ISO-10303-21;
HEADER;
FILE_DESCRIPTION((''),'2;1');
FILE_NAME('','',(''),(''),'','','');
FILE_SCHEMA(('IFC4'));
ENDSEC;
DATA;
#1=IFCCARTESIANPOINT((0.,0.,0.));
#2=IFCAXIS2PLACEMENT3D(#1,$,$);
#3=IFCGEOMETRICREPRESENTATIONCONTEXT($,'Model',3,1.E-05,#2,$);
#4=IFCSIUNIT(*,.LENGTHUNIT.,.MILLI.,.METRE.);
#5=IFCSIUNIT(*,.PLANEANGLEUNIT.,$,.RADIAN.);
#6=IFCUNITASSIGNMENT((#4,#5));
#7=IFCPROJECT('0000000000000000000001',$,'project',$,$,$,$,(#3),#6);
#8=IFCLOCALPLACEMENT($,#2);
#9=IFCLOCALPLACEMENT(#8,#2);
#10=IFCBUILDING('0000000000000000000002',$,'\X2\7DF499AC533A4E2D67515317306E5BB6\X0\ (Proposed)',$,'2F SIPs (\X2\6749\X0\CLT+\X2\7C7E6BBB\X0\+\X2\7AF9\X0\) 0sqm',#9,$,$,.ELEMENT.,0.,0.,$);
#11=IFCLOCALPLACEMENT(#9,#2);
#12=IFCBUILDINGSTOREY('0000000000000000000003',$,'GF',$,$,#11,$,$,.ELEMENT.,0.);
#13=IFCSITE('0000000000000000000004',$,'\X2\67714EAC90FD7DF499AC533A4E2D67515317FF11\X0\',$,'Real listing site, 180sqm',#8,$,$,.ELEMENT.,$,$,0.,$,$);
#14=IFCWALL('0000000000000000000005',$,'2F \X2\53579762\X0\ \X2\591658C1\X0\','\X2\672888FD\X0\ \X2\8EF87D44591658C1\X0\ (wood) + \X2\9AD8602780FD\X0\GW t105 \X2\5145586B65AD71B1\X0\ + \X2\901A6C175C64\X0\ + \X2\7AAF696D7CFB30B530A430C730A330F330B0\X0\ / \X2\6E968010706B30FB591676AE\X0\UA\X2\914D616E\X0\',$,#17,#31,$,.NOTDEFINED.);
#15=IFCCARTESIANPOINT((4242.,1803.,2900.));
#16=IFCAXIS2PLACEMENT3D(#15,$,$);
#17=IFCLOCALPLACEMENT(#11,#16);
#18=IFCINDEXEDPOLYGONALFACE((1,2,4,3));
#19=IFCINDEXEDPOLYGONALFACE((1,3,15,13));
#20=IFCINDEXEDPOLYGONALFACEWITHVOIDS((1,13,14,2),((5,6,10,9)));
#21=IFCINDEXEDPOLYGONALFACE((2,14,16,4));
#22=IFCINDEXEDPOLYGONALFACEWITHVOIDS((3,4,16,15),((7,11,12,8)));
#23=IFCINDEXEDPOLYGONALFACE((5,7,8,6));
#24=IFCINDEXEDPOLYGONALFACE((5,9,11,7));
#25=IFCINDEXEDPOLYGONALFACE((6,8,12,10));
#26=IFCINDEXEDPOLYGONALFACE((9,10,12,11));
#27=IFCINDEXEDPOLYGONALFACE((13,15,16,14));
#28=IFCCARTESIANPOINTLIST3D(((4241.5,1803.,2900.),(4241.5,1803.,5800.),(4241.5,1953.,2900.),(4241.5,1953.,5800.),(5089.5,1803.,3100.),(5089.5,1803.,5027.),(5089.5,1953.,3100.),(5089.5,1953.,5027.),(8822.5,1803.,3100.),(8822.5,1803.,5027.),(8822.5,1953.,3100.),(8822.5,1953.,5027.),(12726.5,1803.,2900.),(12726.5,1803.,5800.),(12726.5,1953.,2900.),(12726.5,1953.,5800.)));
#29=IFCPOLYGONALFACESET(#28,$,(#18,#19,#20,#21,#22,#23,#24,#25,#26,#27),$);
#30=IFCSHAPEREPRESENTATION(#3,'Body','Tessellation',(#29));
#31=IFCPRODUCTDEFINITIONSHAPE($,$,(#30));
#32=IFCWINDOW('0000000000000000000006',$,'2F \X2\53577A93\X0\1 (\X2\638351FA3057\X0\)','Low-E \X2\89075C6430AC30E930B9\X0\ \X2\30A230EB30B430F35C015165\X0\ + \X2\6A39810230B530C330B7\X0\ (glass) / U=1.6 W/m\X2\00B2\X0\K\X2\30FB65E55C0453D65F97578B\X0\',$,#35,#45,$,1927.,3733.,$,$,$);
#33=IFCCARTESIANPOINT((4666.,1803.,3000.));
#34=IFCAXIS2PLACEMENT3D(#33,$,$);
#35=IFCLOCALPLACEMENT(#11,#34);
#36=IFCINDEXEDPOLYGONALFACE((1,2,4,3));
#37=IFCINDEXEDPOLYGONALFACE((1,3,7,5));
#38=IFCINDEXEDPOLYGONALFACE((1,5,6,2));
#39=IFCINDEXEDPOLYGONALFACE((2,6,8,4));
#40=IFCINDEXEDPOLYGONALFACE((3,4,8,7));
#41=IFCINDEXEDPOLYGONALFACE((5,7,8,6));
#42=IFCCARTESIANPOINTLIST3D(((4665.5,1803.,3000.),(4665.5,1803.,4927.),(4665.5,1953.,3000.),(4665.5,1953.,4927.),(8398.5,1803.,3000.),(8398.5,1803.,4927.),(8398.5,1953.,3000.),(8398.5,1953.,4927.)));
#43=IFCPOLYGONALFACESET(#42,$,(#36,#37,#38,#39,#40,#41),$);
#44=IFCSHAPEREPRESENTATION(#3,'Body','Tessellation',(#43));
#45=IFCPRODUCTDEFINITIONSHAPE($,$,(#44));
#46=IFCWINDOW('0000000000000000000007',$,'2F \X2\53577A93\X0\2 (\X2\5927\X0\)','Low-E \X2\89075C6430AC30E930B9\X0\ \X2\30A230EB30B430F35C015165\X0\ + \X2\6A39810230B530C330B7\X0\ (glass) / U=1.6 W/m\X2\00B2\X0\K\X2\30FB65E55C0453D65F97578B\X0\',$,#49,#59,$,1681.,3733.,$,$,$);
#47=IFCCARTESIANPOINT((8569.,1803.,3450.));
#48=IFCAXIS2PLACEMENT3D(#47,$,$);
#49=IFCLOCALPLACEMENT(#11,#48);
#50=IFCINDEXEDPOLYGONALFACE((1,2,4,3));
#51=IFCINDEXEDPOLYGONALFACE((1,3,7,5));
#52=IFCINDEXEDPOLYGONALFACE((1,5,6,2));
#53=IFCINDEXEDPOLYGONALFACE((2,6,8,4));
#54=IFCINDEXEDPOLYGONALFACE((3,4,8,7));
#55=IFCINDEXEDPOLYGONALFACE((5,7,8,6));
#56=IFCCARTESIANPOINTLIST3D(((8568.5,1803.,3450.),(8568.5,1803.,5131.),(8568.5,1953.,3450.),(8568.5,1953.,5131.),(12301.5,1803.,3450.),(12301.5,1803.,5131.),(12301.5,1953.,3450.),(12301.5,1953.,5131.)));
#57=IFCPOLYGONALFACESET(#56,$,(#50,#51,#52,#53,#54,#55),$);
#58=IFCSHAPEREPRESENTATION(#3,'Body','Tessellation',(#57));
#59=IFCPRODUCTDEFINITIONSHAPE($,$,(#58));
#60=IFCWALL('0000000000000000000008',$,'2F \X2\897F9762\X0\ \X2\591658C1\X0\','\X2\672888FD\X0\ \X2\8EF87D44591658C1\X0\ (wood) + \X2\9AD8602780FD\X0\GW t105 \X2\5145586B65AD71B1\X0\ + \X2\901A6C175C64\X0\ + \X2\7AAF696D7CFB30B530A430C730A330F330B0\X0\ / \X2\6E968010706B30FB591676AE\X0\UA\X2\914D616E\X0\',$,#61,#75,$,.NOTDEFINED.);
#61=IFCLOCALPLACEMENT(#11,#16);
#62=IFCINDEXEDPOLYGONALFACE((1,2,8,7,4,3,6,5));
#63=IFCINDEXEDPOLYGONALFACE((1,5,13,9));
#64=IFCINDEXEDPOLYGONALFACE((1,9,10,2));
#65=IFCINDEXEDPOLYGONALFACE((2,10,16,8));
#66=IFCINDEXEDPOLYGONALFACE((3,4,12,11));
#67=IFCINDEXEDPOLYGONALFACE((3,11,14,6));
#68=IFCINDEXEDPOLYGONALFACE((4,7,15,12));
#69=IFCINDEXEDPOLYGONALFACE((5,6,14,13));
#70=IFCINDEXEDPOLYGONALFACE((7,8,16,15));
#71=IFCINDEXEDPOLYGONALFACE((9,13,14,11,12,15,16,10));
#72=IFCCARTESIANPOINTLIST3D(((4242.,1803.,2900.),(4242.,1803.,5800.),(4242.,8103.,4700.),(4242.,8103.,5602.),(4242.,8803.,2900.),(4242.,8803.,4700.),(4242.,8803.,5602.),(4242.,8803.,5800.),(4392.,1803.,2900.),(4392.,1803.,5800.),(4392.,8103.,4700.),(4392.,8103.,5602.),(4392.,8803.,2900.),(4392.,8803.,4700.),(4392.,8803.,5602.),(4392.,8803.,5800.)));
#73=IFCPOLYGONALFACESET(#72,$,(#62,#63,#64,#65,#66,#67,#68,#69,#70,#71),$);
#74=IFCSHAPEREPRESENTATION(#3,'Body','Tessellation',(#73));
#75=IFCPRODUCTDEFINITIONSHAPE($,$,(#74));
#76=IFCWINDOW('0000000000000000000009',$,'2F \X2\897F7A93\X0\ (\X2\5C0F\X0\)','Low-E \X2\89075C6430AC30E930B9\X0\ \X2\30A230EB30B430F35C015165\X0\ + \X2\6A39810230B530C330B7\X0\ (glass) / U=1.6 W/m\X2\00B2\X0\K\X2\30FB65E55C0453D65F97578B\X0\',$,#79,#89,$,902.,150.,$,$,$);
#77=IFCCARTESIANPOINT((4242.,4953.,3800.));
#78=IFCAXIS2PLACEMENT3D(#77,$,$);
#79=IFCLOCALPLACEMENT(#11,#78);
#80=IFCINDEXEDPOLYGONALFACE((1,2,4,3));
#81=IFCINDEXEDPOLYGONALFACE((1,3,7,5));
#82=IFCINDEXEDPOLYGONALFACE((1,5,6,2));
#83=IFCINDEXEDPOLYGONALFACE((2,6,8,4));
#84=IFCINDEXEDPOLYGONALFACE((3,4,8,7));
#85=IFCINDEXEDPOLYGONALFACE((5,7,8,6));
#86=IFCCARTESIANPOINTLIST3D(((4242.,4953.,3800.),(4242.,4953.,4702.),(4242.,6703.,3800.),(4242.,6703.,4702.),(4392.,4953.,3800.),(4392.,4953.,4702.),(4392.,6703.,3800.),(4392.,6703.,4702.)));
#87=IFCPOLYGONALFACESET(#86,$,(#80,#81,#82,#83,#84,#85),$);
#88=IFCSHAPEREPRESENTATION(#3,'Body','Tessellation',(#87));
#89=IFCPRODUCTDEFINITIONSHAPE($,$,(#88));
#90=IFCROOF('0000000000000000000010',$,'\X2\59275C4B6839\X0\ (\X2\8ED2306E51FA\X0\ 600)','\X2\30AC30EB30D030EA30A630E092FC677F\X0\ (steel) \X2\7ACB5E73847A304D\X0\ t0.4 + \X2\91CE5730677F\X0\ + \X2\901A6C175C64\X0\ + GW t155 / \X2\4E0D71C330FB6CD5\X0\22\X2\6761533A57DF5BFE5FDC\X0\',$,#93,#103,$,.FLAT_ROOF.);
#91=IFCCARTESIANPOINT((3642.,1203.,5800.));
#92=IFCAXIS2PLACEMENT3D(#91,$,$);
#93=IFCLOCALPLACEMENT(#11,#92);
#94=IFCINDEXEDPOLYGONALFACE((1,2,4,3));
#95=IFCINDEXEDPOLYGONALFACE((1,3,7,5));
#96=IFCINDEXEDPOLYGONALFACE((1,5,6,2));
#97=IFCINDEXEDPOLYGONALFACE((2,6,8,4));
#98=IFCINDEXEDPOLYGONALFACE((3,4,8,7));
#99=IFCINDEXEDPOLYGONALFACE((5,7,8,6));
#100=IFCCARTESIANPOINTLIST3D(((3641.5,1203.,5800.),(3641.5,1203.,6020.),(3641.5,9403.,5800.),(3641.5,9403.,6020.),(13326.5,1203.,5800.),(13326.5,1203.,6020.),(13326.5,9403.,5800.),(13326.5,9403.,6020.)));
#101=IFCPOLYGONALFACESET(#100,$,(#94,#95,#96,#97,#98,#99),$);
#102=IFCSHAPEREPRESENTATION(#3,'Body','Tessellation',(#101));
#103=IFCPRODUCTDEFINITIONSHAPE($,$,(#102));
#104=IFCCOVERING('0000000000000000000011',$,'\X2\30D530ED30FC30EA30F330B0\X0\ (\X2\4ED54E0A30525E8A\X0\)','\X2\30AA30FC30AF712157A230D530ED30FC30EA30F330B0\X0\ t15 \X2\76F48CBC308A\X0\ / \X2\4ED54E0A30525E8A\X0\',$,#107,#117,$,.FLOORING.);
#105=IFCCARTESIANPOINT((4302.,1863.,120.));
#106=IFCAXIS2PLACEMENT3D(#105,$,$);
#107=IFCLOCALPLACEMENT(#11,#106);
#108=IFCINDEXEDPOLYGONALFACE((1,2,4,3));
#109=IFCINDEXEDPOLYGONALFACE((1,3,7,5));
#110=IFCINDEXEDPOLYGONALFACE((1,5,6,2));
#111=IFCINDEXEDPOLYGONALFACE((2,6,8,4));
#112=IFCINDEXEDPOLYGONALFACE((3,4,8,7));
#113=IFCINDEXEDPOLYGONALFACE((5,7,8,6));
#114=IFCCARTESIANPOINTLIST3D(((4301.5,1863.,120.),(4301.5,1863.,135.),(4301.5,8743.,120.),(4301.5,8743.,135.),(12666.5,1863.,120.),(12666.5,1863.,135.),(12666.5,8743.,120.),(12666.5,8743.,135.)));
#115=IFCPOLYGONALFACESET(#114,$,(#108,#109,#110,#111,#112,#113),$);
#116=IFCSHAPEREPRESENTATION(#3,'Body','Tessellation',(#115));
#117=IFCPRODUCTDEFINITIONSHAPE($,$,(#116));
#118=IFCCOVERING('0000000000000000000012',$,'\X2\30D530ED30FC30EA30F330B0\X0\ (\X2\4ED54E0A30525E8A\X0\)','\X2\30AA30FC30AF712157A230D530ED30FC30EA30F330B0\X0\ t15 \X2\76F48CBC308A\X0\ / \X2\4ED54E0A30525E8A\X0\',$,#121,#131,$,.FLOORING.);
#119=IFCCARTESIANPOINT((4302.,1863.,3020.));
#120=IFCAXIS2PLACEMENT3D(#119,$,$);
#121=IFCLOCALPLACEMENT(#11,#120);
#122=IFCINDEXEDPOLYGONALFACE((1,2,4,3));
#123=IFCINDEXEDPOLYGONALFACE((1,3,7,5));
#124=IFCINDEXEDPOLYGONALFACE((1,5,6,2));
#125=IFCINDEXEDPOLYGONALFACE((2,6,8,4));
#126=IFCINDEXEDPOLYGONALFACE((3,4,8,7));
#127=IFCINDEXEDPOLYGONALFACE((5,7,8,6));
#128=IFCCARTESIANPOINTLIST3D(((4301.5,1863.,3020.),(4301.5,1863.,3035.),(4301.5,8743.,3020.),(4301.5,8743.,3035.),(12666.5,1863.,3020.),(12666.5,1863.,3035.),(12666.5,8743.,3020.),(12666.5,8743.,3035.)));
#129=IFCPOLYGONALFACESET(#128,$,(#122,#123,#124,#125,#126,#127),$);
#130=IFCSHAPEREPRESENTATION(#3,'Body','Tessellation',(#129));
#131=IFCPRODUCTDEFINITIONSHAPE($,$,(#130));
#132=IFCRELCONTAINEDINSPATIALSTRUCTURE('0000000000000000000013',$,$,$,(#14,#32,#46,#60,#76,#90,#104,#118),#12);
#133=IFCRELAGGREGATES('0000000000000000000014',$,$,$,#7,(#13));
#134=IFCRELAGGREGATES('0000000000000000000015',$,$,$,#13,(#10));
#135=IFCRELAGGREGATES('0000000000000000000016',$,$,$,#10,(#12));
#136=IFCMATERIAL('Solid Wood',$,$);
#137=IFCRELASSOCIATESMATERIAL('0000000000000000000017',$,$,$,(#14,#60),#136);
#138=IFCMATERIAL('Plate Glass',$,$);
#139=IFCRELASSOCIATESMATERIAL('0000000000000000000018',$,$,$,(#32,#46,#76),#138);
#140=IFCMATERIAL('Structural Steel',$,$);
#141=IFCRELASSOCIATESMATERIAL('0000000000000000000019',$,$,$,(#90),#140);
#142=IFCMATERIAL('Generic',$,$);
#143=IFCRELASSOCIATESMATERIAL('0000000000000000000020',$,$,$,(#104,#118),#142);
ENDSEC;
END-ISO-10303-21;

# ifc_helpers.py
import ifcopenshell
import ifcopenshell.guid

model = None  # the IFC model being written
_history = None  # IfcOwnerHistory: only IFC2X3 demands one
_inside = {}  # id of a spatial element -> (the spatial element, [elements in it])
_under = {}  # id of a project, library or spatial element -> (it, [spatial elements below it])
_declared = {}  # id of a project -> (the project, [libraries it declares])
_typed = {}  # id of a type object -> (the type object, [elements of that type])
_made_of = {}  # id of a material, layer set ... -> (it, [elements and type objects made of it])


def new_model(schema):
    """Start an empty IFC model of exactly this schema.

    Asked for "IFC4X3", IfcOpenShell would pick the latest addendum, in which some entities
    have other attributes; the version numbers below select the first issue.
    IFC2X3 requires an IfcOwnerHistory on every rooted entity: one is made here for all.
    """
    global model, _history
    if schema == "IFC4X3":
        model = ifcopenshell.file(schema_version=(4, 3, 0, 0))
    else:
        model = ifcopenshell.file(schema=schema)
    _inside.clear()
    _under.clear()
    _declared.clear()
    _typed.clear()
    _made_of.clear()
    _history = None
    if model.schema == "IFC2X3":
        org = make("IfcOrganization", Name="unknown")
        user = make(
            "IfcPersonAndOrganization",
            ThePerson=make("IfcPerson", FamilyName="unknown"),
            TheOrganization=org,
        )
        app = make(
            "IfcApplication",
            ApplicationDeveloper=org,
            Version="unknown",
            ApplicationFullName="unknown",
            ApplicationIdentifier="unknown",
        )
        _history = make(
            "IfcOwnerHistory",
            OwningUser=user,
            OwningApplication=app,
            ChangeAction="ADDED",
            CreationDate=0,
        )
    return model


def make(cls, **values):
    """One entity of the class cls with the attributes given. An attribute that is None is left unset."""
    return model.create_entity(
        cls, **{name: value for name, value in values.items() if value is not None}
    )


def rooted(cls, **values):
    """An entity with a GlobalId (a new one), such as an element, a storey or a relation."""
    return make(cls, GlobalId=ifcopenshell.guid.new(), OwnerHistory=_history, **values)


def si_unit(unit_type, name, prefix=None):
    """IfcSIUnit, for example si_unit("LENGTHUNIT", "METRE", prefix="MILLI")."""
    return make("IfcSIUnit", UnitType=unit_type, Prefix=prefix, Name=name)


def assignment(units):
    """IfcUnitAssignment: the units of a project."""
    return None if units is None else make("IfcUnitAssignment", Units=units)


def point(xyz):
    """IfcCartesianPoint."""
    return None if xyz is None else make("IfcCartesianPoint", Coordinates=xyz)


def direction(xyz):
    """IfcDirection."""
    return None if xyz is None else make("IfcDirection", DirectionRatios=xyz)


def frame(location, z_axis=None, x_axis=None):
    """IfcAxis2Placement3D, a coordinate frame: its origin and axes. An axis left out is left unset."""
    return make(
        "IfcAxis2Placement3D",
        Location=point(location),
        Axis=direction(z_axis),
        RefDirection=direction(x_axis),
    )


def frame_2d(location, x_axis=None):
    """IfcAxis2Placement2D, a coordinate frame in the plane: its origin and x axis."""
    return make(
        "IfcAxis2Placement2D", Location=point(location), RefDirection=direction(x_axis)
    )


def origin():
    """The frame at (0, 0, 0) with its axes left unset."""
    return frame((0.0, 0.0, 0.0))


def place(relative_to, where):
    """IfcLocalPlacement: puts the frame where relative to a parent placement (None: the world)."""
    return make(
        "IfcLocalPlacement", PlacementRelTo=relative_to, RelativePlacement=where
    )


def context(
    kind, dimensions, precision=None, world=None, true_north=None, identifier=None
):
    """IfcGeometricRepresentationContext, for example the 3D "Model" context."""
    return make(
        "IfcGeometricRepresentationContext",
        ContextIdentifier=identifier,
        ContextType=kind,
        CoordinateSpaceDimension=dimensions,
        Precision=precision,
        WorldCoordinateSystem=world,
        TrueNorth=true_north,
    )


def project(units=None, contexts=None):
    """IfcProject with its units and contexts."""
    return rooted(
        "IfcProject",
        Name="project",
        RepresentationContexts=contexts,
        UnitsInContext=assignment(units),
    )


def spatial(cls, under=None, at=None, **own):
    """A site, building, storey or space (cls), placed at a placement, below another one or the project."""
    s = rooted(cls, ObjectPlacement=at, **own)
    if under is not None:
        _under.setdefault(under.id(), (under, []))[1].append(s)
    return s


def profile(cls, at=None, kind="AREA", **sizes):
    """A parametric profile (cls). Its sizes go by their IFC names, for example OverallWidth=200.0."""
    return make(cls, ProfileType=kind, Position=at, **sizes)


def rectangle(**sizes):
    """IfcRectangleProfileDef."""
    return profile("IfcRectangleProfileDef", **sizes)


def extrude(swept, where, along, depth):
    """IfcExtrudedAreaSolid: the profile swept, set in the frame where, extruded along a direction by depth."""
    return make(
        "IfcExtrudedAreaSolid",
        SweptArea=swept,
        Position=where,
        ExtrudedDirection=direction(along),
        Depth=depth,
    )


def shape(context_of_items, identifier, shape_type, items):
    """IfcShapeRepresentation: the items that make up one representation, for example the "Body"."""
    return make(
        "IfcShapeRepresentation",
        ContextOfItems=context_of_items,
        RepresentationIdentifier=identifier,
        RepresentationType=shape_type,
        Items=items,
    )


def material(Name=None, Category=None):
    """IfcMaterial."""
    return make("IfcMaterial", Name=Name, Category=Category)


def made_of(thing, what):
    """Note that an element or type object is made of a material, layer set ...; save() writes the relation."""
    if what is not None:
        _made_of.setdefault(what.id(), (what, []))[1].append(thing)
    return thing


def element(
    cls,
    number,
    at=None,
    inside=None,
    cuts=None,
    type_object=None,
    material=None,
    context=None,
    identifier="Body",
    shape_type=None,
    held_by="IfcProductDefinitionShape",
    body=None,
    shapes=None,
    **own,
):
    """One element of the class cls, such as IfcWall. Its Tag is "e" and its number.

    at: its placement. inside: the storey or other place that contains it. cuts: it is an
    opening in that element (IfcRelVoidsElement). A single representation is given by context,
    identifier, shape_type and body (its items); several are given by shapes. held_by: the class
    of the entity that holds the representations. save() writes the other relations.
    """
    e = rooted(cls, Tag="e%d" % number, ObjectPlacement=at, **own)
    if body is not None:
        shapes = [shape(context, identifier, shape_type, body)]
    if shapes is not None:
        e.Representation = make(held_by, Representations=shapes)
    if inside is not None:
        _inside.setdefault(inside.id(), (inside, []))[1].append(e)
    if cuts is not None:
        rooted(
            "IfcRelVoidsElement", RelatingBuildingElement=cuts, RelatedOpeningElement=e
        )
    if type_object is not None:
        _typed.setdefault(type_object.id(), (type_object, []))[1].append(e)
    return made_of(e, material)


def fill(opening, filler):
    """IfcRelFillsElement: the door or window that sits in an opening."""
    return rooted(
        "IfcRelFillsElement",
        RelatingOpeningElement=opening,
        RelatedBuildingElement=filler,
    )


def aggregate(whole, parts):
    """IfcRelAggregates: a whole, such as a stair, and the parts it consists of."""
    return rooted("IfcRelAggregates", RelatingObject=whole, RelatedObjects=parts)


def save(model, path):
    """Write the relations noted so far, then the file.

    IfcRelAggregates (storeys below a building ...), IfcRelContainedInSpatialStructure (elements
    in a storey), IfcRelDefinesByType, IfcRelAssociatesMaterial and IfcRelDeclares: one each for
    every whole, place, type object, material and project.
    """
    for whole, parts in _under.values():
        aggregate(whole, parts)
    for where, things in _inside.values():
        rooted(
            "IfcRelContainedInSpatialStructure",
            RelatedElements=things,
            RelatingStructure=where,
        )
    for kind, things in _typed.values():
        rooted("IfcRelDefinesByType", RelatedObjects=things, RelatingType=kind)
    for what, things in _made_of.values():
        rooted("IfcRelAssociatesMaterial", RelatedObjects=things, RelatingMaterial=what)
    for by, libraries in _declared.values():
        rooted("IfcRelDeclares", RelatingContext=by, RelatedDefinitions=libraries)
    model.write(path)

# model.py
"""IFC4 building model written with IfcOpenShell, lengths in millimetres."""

from ifc_helpers import new_model, si_unit, frame, frame_2d, origin, place, context, project, spatial, rectangle, extrude, material, element, fill, save


model = new_model("IFC4")

# Units and contexts
model_context = context("Model", 3, precision=1e-05, world=origin())
ifc_project = project(units=[si_unit("LENGTHUNIT", "METRE", prefix="MILLI"), si_unit("PLANEANGLEUNIT", "RADIAN")], contexts=[model_context])

# Site, building, storey
site_placement = place(None, origin())
site = spatial("IfcSite", under=ifc_project, at=site_placement, Name="東京都練馬区中村北１", ObjectType="Real listing site, 180sqm", CompositionType="ELEMENT", RefElevation=0.0)
building_placement = place(site_placement, origin())
building = spatial("IfcBuilding", under=site, at=building_placement, Name="練馬区中村北の家 (Proposed)", ObjectType="2F SIPs (杉CLT+籾殻+竹) 0sqm", CompositionType="ELEMENT", ElevationOfRefHeight=0.0, ElevationOfTerrain=0.0)
storey_placement = place(building_placement, origin())
storey = spatial("IfcBuildingStorey", under=building, at=storey_placement, Name="GF", CompositionType="ELEMENT", Elevation=0.0)

# Shared definitions
ifc_material_1 = material(Name="Solid Wood")

# Shared definitions
ifc_material_2 = material(Name="Plate Glass")

# Wall, openings, windows
wall_1_placement = place(storey_placement, frame((4242.0, 1803.0, 2900.0)))
wall_1 = element("IfcWall", 1, at=wall_1_placement, inside=storey, material=ifc_material_1, Name="2F 南面 外壁", Description="木製 軸組外壁 (wood) + 高性能GW t105 充填断熱 + 通気層 + 窯業系サイディング / 準耐火・外皮UA配慮", PredefinedType="NOTDEFINED", context=model_context, shape_type="SweptSolid", body=[
    extrude(rectangle(XDim=8485.0, YDim=150.0, at=frame_2d((4242.0, 75.0))), frame((4242.0, 1803.0, 2900.0)), (0.0, 0.0, 1.0), 2900.0),
])
opening_1_placement = place(storey_placement, frame((4666.0, 1803.0, 3000.0)))
opening_1 = element("IfcOpeningElement", 2, at=opening_1_placement, cuts=wall_1, PredefinedType="NOTDEFINED", context=model_context, shape_type="SweptSolid", body=[
    extrude(rectangle(XDim=3733.0, YDim=150.0, at=frame_2d((1866.0, 75.0))), frame((4666.0, 1803.0, 3000.0)), (0.0, 0.0, 1.0), 1927.0),
])
opening_2_placement = place(storey_placement, frame((8569.0, 1803.0, 3450.0)))
opening_2 = element("IfcOpeningElement", 3, at=opening_2_placement, cuts=wall_1, PredefinedType="NOTDEFINED", context=model_context, shape_type="SweptSolid", body=[
    extrude(rectangle(XDim=3733.0, YDim=150.0, at=frame_2d((1866.0, 75.0))), frame((8569.0, 1803.0, 3450.0)), (0.0, 0.0, 1.0), 1681.0),
])
window_1_placement = place(storey_placement, frame((4666.0, 1803.0, 3000.0)))
window_1 = element("IfcWindow", 4, at=window_1_placement, inside=storey, material=ifc_material_2, Name="2F 南窓1 (掃出し)", Description="Low-E 複層ガラス アルゴン封入 + 樹脂サッシ (glass) / U=1.6 W/m²K・日射取得型", OverallHeight=1927.0, OverallWidth=3733.0, context=model_context, shape_type="SweptSolid", body=[
    extrude(rectangle(XDim=3733.0, YDim=150.0, at=frame_2d((1866.0, 75.0))), frame((4666.0, 1803.0, 3000.0)), (0.0, 0.0, 1.0), 1927.0),
])
fill(opening_1, window_1)
window_2_placement = place(storey_placement, frame((8569.0, 1803.0, 3450.0)))
window_2 = element("IfcWindow", 5, at=window_2_placement, inside=storey, material=ifc_material_2, Name="2F 南窓2 (大)", Description="Low-E 複層ガラス アルゴン封入 + 樹脂サッシ (glass) / U=1.6 W/m²K・日射取得型", OverallHeight=1681.0, OverallWidth=3733.0, context=model_context, shape_type="SweptSolid", body=[
    extrude(rectangle(XDim=3733.0, YDim=150.0, at=frame_2d((1866.0, 75.0))), frame((8569.0, 1803.0, 3450.0)), (0.0, 0.0, 1.0), 1681.0),
])
fill(opening_2, window_2)

# Wall, opening, window
wall_2_placement = place(storey_placement, frame((4242.0, 1803.0, 2900.0)))
wall_2 = element("IfcWall", 6, at=wall_2_placement, inside=storey, material=ifc_material_1, Name="2F 西面 外壁", Description="木製 軸組外壁 (wood) + 高性能GW t105 充填断熱 + 通気層 + 窯業系サイディング / 準耐火・外皮UA配慮", PredefinedType="NOTDEFINED", context=model_context, shape_type="SweptSolid", body=[
    extrude(rectangle(XDim=150.0, YDim=7000.0, at=frame_2d((75.0, 3500.0))), frame((4242.0, 1803.0, 2900.0)), (0.0, 0.0, 1.0), 2900.0),
])
opening_3_placement = place(storey_placement, frame((4242.0, 4953.0, 3800.0)))
opening_3 = element("IfcOpeningElement", 7, at=opening_3_placement, cuts=wall_2, PredefinedType="NOTDEFINED", context=model_context, shape_type="SweptSolid", body=[
    extrude(rectangle(XDim=150.0, YDim=1750.0, at=frame_2d((75.0, 875.0))), frame((4242.0, 4953.0, 3800.0)), (0.0, 0.0, 1.0), 902.0),
])
window_3_placement = place(storey_placement, frame((4242.0, 4953.0, 3800.0)))
window_3 = element("IfcWindow", 8, at=window_3_placement, inside=storey, material=ifc_material_2, Name="2F 西窓 (小)", Description="Low-E 複層ガラス アルゴン封入 + 樹脂サッシ (glass) / U=1.6 W/m²K・日射取得型", OverallHeight=902.0, OverallWidth=150.0, context=model_context, shape_type="SweptSolid", body=[
    extrude(rectangle(XDim=150.0, YDim=1750.0, at=frame_2d((75.0, 875.0))), frame((4242.0, 4953.0, 3800.0)), (0.0, 0.0, 1.0), 902.0),
])
fill(opening_3, window_3)

# Roof
ifc_material_3 = material(Name="Structural Steel")
roof_placement = place(storey_placement, frame((3642.0, 1203.0, 5800.0)))
element("IfcRoof", 9, at=roof_placement, inside=storey, material=ifc_material_3, Name="大屋根 (軒の出 600)", Description="ガルバリウム鋼板 (steel) 立平葺き t0.4 + 野地板 + 通気層 + GW t155 / 不燃・法22条区域対応", PredefinedType="FLAT_ROOF", context=model_context, shape_type="SweptSolid", body=[
    extrude(rectangle(XDim=9685.0, YDim=8200.0, at=frame_2d((4842.0, 4100.0))), frame((3642.0, 1203.0, 5800.0)), (0.0, 0.0, 1.0), 220.0),
])

# Coverings
ifc_material_4 = material(Name="Generic")
covering_1_placement = place(storey_placement, frame((4302.0, 1863.0, 120.0)))
element("IfcCovering", 10, at=covering_1_placement, inside=storey, material=ifc_material_4, Name="フローリング (仕上げ床)", Description="オーク無垢フローリング t15 直貼り / 仕上げ床", PredefinedType="FLOORING", context=model_context, shape_type="SweptSolid", body=[
    extrude(rectangle(XDim=8365.0, YDim=6880.0, at=frame_2d((4182.0, 3440.0))), frame((4302.0, 1863.0, 120.0)), (0.0, 0.0, 1.0), 15.0),
])
covering_2_placement = place(storey_placement, frame((4302.0, 1863.0, 3020.0)))
element("IfcCovering", 11, at=covering_2_placement, inside=storey, material=ifc_material_4, Name="フローリング (仕上げ床)", Description="オーク無垢フローリング t15 直貼り / 仕上げ床", PredefinedType="FLOORING", context=model_context, shape_type="SweptSolid", body=[
    extrude(rectangle(XDim=8365.0, YDim=6880.0, at=frame_2d((4182.0, 3440.0))), frame((4302.0, 1863.0, 3020.0)), (0.0, 0.0, 1.0), 15.0),
])

save(model, "model.ifc")
